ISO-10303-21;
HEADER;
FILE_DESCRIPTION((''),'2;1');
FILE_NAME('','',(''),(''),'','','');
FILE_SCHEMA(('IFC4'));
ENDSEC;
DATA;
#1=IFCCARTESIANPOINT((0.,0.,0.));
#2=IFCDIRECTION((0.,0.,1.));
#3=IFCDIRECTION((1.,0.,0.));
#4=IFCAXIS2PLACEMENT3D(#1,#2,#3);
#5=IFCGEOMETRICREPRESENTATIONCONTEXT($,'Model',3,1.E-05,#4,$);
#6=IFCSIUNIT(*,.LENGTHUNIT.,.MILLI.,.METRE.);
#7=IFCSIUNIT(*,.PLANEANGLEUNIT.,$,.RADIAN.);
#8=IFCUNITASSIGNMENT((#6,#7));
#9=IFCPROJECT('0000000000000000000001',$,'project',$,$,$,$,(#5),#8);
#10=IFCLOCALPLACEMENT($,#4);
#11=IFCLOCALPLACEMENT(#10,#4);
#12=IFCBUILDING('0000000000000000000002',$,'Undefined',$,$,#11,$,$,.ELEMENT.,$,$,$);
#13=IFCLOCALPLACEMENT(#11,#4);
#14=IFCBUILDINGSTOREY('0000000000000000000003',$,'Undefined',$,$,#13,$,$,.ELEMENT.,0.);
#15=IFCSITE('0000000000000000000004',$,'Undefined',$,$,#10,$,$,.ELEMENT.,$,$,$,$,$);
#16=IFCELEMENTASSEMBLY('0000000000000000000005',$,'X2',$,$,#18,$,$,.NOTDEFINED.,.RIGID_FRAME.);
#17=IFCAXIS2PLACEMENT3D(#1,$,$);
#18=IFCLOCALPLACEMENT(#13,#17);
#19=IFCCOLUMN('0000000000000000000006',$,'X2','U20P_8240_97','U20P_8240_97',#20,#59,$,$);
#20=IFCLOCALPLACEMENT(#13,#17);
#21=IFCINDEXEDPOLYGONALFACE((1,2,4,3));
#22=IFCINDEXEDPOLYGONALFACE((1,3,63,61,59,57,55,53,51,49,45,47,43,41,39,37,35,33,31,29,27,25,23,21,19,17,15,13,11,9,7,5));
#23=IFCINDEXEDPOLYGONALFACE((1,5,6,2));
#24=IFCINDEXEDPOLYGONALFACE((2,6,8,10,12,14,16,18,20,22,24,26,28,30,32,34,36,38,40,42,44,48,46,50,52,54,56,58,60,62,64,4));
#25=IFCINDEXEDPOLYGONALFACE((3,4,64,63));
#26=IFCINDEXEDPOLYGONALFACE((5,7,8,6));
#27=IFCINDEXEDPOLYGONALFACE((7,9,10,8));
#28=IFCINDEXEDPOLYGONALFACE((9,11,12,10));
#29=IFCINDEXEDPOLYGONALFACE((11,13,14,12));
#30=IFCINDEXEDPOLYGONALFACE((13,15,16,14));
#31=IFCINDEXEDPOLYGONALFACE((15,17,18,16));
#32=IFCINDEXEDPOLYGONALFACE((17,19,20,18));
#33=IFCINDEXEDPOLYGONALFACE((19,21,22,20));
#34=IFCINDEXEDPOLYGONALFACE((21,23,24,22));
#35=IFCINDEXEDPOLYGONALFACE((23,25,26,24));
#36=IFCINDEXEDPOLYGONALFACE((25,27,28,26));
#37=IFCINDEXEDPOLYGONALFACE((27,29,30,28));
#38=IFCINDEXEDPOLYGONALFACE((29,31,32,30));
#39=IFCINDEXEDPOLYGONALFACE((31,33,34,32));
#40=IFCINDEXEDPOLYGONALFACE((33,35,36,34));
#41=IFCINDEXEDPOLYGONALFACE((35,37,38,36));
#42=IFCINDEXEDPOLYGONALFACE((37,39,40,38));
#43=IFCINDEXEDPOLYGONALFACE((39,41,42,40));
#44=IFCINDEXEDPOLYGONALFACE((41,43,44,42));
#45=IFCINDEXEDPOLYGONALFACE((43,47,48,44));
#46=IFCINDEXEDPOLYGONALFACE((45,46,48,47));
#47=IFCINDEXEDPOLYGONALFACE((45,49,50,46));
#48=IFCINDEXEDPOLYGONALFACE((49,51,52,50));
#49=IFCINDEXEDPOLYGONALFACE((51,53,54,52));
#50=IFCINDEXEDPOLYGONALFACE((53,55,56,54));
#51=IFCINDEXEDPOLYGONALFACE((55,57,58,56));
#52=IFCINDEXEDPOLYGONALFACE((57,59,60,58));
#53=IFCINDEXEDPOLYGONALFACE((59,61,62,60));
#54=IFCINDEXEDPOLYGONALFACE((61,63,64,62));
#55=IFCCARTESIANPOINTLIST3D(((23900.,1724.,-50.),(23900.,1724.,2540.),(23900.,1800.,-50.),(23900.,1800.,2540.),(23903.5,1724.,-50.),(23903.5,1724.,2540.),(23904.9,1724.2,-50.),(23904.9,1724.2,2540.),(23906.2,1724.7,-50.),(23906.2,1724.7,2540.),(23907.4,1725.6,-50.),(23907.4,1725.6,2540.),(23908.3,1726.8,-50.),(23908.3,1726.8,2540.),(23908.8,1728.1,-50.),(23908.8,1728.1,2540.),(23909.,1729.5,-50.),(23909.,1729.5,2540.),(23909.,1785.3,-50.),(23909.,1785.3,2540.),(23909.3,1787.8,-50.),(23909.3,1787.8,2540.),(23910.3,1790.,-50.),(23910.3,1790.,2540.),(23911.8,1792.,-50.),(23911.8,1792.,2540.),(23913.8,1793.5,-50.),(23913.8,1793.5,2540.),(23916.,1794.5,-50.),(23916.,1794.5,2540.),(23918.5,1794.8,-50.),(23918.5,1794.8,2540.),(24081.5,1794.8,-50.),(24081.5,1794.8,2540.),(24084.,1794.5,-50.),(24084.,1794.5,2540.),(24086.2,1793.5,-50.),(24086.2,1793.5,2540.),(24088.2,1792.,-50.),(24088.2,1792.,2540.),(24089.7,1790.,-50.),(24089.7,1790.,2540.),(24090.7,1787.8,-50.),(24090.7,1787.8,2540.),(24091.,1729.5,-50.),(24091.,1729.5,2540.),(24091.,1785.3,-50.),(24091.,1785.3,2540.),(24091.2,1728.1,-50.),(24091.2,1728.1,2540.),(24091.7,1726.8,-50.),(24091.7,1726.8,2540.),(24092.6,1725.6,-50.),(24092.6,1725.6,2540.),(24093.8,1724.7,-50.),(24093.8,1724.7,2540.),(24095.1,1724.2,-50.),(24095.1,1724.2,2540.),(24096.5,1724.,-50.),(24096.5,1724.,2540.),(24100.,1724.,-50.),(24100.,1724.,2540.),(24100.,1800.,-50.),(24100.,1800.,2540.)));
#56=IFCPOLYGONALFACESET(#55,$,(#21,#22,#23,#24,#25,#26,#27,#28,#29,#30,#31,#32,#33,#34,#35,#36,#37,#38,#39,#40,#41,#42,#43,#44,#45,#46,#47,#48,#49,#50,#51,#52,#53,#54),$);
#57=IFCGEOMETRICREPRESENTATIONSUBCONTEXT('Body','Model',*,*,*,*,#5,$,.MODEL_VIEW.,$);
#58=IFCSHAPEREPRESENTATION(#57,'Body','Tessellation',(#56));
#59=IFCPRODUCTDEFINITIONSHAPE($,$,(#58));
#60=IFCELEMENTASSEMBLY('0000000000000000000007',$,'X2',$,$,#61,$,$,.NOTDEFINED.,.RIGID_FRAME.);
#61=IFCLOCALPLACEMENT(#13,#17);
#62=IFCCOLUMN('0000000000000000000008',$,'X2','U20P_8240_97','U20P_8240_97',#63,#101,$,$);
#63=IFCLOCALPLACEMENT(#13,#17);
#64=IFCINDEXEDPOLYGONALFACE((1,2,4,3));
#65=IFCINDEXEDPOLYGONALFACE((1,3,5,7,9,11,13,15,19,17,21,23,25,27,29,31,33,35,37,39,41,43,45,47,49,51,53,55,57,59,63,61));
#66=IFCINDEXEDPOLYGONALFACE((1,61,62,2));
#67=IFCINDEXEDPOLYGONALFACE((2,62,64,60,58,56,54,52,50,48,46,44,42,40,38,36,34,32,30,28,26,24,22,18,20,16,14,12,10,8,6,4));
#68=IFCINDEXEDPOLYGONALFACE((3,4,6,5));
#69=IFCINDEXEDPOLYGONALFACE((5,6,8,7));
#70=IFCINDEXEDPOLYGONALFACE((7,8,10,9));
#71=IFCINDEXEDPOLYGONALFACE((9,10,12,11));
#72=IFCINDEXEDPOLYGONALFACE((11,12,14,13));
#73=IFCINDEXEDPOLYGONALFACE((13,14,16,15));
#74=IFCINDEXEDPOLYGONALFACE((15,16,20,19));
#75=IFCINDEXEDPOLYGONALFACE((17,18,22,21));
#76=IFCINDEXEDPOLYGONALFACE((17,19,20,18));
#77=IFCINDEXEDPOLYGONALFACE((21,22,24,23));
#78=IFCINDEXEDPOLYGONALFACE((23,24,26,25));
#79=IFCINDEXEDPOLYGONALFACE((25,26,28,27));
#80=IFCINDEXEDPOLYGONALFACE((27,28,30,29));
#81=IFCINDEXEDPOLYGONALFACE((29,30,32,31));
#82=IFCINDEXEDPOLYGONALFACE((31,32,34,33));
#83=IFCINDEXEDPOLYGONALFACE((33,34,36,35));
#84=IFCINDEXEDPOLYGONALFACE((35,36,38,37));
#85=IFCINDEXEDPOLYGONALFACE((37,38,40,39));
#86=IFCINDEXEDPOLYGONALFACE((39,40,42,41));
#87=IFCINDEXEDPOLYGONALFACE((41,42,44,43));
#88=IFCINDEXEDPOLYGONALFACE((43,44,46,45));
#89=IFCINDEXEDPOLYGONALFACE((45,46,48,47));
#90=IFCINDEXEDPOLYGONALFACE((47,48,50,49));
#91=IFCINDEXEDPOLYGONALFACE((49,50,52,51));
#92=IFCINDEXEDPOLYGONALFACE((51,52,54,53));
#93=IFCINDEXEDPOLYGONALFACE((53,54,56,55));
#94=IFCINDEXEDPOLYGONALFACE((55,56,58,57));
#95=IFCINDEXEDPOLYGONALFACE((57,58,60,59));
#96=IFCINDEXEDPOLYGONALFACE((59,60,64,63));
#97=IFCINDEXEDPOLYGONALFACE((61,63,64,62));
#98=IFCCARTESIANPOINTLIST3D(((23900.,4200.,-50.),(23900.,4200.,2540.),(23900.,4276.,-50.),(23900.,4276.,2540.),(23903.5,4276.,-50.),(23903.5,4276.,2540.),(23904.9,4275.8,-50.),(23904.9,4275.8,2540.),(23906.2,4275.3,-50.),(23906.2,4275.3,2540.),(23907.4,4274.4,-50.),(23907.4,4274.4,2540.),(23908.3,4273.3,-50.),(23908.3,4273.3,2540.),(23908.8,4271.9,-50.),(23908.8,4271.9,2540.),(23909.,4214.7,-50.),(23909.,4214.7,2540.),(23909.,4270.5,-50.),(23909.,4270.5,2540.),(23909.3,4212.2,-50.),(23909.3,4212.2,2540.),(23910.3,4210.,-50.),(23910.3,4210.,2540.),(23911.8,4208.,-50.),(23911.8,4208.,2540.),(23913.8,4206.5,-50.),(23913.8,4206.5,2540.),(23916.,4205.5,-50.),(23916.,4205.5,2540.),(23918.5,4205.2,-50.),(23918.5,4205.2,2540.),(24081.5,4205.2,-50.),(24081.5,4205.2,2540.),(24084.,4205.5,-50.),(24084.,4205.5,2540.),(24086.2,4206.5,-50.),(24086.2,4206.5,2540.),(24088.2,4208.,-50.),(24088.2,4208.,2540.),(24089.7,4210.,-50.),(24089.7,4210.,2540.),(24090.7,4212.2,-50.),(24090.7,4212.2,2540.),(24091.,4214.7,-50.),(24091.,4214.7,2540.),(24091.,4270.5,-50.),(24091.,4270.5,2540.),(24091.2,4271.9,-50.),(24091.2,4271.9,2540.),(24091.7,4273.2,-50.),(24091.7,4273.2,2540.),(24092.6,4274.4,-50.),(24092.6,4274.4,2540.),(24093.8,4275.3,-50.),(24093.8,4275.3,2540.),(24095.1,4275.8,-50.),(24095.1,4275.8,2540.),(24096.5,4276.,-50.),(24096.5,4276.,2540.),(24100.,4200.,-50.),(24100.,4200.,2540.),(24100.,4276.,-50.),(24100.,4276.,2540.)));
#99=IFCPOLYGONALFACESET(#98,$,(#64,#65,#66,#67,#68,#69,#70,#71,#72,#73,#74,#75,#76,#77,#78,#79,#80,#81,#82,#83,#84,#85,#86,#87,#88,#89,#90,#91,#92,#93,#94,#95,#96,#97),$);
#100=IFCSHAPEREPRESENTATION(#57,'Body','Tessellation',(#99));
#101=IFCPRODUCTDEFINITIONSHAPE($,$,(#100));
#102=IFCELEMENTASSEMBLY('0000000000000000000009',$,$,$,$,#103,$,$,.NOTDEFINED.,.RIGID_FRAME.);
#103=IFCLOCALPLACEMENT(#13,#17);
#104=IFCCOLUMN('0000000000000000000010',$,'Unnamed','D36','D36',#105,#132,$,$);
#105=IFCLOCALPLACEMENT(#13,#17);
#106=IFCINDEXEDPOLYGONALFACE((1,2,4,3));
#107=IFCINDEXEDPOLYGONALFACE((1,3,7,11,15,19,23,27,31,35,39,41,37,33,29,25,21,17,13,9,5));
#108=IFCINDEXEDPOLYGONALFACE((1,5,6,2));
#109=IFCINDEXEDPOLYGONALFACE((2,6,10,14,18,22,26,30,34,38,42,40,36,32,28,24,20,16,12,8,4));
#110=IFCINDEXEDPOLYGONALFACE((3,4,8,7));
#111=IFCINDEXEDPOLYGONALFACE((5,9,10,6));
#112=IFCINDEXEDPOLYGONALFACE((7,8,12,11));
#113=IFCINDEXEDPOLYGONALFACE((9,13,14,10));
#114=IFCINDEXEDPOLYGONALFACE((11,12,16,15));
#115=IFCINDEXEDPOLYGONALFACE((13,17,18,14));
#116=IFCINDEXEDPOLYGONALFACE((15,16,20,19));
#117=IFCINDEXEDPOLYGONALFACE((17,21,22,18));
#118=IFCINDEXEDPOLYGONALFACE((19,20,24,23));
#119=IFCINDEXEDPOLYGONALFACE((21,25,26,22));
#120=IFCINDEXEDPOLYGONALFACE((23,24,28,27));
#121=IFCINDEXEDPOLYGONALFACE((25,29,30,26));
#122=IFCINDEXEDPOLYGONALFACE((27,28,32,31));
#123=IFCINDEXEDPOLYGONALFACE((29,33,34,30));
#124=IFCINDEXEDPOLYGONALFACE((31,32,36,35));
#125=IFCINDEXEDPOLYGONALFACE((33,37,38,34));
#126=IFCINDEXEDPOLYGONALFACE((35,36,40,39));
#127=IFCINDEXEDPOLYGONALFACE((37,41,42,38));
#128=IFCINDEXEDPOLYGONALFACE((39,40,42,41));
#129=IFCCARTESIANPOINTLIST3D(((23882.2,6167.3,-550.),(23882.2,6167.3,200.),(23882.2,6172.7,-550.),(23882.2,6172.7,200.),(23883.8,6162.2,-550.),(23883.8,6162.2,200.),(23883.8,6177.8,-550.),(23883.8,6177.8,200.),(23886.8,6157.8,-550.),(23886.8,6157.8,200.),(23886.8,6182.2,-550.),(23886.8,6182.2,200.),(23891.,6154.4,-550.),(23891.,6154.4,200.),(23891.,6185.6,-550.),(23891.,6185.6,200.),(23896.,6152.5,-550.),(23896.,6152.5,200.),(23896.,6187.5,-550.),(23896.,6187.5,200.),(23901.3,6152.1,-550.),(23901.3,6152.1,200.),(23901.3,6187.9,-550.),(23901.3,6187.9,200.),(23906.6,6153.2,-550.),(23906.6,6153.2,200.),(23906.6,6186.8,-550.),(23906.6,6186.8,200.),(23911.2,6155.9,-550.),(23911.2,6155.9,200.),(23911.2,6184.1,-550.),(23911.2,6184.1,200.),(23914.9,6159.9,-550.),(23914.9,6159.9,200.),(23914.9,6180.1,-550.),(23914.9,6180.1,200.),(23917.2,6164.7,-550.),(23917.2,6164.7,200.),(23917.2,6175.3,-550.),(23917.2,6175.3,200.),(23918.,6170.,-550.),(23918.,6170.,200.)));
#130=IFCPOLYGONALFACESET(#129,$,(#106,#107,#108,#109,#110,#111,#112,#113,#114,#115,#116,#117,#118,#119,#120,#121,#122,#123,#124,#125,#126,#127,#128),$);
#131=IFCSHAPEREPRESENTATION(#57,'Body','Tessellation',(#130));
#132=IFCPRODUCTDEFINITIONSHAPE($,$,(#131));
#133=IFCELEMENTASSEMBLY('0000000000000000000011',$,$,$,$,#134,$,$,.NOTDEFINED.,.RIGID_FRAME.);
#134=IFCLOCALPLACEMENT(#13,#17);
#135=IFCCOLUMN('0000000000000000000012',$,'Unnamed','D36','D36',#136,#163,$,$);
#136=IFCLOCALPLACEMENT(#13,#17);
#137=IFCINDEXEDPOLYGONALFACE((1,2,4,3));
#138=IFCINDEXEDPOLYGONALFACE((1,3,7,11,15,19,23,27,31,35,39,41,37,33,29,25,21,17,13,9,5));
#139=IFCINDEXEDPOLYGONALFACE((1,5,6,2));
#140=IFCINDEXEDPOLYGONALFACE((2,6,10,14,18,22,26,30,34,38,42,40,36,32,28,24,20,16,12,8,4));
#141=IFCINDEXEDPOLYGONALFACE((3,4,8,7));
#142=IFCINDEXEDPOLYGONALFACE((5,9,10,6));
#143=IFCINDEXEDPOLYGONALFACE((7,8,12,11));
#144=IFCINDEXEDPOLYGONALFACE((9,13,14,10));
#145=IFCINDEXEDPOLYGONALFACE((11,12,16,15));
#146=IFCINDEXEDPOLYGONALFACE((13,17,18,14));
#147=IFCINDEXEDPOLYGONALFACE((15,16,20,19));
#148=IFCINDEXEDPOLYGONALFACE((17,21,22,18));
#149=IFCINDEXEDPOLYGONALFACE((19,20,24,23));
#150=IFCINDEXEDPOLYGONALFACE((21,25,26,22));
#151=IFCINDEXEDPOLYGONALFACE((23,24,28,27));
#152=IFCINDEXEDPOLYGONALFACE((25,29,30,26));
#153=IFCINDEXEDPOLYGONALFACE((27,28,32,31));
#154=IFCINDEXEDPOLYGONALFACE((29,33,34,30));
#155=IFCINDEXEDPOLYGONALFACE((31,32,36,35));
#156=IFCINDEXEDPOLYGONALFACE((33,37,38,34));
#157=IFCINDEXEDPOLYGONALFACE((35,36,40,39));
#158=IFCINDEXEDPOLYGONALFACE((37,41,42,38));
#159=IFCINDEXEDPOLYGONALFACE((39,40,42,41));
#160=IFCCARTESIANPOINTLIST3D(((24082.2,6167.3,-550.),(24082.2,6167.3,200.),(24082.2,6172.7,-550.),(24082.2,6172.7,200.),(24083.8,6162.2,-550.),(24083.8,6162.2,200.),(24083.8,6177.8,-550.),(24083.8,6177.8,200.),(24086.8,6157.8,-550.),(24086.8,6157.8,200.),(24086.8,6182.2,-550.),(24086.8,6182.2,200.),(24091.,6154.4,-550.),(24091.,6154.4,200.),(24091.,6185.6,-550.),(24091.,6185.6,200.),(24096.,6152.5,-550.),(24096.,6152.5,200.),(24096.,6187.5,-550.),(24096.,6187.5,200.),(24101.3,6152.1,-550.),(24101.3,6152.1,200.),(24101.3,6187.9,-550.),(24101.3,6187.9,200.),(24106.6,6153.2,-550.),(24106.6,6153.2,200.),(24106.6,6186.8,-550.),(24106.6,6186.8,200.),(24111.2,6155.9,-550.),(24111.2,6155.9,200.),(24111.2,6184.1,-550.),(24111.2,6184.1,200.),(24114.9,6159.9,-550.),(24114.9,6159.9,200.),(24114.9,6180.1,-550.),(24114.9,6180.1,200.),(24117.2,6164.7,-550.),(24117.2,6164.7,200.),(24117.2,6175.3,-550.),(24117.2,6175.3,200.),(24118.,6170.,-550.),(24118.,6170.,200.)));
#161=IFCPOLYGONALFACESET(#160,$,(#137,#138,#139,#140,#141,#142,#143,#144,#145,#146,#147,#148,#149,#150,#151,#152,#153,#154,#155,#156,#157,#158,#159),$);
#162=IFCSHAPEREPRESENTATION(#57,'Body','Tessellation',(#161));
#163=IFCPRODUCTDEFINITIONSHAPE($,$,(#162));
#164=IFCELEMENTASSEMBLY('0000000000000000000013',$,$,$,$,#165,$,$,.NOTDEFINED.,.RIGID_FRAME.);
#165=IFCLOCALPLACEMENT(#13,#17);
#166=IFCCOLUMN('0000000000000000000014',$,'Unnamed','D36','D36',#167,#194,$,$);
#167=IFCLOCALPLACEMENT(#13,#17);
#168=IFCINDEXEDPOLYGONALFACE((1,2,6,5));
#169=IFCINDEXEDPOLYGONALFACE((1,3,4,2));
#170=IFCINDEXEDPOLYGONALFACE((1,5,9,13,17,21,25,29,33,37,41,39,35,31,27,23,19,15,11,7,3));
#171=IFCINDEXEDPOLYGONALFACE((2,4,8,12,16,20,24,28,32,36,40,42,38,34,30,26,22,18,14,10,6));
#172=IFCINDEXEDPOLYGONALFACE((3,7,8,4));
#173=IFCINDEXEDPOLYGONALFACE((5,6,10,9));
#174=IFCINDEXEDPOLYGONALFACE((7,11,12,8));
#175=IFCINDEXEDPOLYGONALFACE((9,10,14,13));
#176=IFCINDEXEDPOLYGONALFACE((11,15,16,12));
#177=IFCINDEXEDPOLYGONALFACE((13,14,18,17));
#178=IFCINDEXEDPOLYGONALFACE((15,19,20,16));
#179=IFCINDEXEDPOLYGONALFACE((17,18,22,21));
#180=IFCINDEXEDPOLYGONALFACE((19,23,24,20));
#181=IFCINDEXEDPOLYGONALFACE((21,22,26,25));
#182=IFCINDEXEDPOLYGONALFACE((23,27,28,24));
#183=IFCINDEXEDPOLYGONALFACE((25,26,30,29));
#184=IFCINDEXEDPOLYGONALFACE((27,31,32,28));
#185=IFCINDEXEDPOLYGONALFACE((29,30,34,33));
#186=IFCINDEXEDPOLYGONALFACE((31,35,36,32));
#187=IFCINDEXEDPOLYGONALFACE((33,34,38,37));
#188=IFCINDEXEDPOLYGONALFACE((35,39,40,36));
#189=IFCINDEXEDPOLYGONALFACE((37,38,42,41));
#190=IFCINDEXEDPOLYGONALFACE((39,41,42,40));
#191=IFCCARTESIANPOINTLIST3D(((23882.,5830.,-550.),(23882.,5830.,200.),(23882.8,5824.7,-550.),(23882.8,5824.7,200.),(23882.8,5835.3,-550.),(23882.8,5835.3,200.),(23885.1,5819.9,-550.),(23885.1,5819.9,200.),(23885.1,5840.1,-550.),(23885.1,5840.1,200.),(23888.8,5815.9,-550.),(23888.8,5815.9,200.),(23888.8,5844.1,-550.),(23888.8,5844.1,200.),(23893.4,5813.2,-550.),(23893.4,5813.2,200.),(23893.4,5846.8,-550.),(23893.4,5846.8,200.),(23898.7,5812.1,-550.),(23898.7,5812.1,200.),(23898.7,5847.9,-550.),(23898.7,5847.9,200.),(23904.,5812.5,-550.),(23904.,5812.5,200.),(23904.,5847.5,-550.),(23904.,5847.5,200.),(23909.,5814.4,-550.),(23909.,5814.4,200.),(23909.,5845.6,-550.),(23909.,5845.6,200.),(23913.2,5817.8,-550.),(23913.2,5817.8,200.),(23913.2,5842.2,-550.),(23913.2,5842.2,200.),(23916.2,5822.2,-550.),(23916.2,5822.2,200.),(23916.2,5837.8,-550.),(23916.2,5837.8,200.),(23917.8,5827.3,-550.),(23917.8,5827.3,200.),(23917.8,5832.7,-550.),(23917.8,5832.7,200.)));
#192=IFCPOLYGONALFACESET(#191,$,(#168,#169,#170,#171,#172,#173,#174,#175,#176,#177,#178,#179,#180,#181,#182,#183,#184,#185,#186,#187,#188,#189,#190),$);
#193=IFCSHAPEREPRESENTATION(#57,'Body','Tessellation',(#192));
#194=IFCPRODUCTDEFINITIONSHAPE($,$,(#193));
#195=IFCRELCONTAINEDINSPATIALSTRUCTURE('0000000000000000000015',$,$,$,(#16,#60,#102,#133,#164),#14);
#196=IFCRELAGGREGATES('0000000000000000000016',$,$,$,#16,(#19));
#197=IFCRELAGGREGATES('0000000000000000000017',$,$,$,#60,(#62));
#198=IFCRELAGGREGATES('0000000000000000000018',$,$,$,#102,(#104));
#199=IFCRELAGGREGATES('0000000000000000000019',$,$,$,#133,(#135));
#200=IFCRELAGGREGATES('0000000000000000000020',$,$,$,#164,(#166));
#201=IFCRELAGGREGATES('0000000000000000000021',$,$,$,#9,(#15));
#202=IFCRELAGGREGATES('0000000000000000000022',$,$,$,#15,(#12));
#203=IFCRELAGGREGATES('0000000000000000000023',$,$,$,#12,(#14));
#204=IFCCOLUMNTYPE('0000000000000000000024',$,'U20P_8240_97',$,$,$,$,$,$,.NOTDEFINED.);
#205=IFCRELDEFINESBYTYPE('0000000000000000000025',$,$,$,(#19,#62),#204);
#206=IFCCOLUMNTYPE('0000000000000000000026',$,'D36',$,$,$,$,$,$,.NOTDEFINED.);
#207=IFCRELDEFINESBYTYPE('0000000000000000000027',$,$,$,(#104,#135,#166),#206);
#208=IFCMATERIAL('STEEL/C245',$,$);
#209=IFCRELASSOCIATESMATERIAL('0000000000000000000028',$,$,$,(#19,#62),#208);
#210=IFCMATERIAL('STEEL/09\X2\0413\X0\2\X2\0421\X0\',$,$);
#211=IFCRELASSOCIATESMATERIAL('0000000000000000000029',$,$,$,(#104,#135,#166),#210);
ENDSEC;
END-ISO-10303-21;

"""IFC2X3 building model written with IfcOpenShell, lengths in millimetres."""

from ifc_helpers import new_model, si_unit, frame, origin_with_axes, origin_2d_with_axis, place, context, subcontext, project, spatial, circle, u_section, extrude, material, type_object, element, aggregate, save


model = new_model("IFC2X3")

# Units and contexts
model_context = context("Model", 3, precision=1e-05, world=origin_with_axes())
body_context = subcontext(model_context, "Body", "Model", "MODEL_VIEW")
ifc_project = project(units=[si_unit("LENGTHUNIT", "METRE", prefix="MILLI"), si_unit("PLANEANGLEUNIT", "RADIAN")], contexts=[model_context])

# Site, building, storey
site_placement = place(None, origin_with_axes())
site = spatial("IfcSite", under=ifc_project, at=site_placement, Name="Undefined", CompositionType="ELEMENT")
building_placement = place(site_placement, origin_with_axes())
building = spatial("IfcBuilding", under=site, at=building_placement, Name="Undefined", CompositionType="ELEMENT")
storey_placement = place(building_placement, origin_with_axes())
storey = spatial("IfcBuildingStorey", under=building, at=storey_placement, Name="Undefined", CompositionType="ELEMENT", Elevation=0.0)

# Element assemblies, columns
assembly_1_placement = place(storey_placement, origin_with_axes())
assembly_1 = element("IfcElementAssembly", 1, at=assembly_1_placement, inside=storey, Name="X2", AssemblyPlace="NOTDEFINED", PredefinedType="RIGID_FRAME")
ifc_material_1 = material(Name="STEEL/C245")
column_type_1 = type_object("IfcColumnType", Name="U20P_8240_97", PredefinedType="NOTDEFINED")
column_1_placement = place(assembly_1_placement, frame((24000.0, 1762.0, -50.0), z_axis=(0.0, 0.0, 1.0), x_axis=(-1.0, 0.0, 0.0)))
column_1 = element("IfcColumn", 2, at=column_1_placement, type_object=column_type_1, material=ifc_material_1, Name="X2", Description="U20P_8240_97", ObjectType="U20P_8240_97", context=body_context, shape_type="SweptSolid", body=[
    extrude(u_section(Depth=200.0, FlangeWidth=76.0, WebThickness=5.2, FlangeThickness=9.0, FilletRadius=9.5, EdgeRadius=5.5, at=origin_2d_with_axis()), frame((0.0, 0.0, 2590.0), z_axis=(0.0, 0.0, -1.0), x_axis=(0.0, 1.0, 0.0)), (0.0, 0.0, 1.0), 2590.0),
])
aggregate(assembly_1, [column_1])
assembly_2_placement = place(storey_placement, origin_with_axes())
assembly_2 = element("IfcElementAssembly", 3, at=assembly_2_placement, inside=storey, Name="X2", AssemblyPlace="NOTDEFINED", PredefinedType="RIGID_FRAME")
column_2_placement = place(assembly_2_placement, frame((24000.0, 4238.0, -50.0), z_axis=(0.0, 0.0, 1.0), x_axis=(1.0, 0.0, 0.0)))
column_2 = element("IfcColumn", 4, at=column_2_placement, type_object=column_type_1, material=ifc_material_1, Name="X2", Description="U20P_8240_97", ObjectType="U20P_8240_97", context=body_context, shape_type="SweptSolid", body=[
    extrude(u_section(Depth=200.0, FlangeWidth=76.0, WebThickness=5.2, FlangeThickness=9.0, FilletRadius=9.5, EdgeRadius=5.5, at=origin_2d_with_axis()), frame((0.0, 0.0, 2590.0), z_axis=(0.0, 0.0, -1.0), x_axis=(0.0, 1.0, 0.0)), (0.0, 0.0, 1.0), 2590.0),
])
aggregate(assembly_2, [column_2])
assembly_3_placement = place(storey_placement, origin_with_axes())
assembly_3 = element("IfcElementAssembly", 5, at=assembly_3_placement, inside=storey, AssemblyPlace="NOTDEFINED", PredefinedType="RIGID_FRAME")
ifc_material_2 = material(Name="STEEL/09Г2С")
column_type_2 = type_object("IfcColumnType", Name="D36", PredefinedType="NOTDEFINED")
column_3_placement = place(assembly_3_placement, frame((23900.0, 6170.0, -550.0), z_axis=(0.0, 0.0, 1.0), x_axis=(0.0, -1.0, 0.0)))
column_3 = element("IfcColumn", 6, at=column_3_placement, type_object=column_type_2, material=ifc_material_2, Name="Unnamed", Description="D36", ObjectType="D36", context=body_context, shape_type="SweptSolid", body=[
    extrude(circle(Radius=18.0, at=origin_2d_with_axis()), frame((0.0, 0.0, 750.0), z_axis=(0.0, 0.0, -1.0), x_axis=(0.0, 1.0, 0.0)), (0.0, 0.0, 1.0), 750.0),
])
aggregate(assembly_3, [column_3])
assembly_4_placement = place(storey_placement, origin_with_axes())
assembly_4 = element("IfcElementAssembly", 7, at=assembly_4_placement, inside=storey, AssemblyPlace="NOTDEFINED", PredefinedType="RIGID_FRAME")
column_4_placement = place(assembly_4_placement, frame((24100.0, 6170.0, -550.0), z_axis=(0.0, 0.0, 1.0), x_axis=(0.0, -1.0, 0.0)))
column_4 = element("IfcColumn", 8, at=column_4_placement, type_object=column_type_2, material=ifc_material_2, Name="Unnamed", Description="D36", ObjectType="D36", context=body_context, shape_type="SweptSolid", body=[
    extrude(circle(Radius=18.0, at=origin_2d_with_axis()), frame((0.0, 0.0, 750.0), z_axis=(0.0, 0.0, -1.0), x_axis=(0.0, 1.0, 0.0)), (0.0, 0.0, 1.0), 750.0),
])
aggregate(assembly_4, [column_4])
assembly_5_placement = place(storey_placement, origin_with_axes())
assembly_5 = element("IfcElementAssembly", 9, at=assembly_5_placement, inside=storey, AssemblyPlace="NOTDEFINED", PredefinedType="RIGID_FRAME")
column_5_placement = place(assembly_5_placement, frame((23900.0, 5830.0, -550.0), z_axis=(0.0, 0.0, 1.0), x_axis=(0.0, 1.0, 0.0)))
column_5 = element("IfcColumn", 10, at=column_5_placement, type_object=column_type_2, material=ifc_material_2, Name="Unnamed", Description="D36", ObjectType="D36", context=body_context, shape_type="SweptSolid", body=[
    extrude(circle(Radius=18.0, at=origin_2d_with_axis()), frame((0.0, 0.0, 750.0), z_axis=(0.0, 0.0, -1.0), x_axis=(0.0, 1.0, 0.0)), (0.0, 0.0, 1.0), 750.0),
])
aggregate(assembly_5, [column_5])

save(model, "model.ifc")
